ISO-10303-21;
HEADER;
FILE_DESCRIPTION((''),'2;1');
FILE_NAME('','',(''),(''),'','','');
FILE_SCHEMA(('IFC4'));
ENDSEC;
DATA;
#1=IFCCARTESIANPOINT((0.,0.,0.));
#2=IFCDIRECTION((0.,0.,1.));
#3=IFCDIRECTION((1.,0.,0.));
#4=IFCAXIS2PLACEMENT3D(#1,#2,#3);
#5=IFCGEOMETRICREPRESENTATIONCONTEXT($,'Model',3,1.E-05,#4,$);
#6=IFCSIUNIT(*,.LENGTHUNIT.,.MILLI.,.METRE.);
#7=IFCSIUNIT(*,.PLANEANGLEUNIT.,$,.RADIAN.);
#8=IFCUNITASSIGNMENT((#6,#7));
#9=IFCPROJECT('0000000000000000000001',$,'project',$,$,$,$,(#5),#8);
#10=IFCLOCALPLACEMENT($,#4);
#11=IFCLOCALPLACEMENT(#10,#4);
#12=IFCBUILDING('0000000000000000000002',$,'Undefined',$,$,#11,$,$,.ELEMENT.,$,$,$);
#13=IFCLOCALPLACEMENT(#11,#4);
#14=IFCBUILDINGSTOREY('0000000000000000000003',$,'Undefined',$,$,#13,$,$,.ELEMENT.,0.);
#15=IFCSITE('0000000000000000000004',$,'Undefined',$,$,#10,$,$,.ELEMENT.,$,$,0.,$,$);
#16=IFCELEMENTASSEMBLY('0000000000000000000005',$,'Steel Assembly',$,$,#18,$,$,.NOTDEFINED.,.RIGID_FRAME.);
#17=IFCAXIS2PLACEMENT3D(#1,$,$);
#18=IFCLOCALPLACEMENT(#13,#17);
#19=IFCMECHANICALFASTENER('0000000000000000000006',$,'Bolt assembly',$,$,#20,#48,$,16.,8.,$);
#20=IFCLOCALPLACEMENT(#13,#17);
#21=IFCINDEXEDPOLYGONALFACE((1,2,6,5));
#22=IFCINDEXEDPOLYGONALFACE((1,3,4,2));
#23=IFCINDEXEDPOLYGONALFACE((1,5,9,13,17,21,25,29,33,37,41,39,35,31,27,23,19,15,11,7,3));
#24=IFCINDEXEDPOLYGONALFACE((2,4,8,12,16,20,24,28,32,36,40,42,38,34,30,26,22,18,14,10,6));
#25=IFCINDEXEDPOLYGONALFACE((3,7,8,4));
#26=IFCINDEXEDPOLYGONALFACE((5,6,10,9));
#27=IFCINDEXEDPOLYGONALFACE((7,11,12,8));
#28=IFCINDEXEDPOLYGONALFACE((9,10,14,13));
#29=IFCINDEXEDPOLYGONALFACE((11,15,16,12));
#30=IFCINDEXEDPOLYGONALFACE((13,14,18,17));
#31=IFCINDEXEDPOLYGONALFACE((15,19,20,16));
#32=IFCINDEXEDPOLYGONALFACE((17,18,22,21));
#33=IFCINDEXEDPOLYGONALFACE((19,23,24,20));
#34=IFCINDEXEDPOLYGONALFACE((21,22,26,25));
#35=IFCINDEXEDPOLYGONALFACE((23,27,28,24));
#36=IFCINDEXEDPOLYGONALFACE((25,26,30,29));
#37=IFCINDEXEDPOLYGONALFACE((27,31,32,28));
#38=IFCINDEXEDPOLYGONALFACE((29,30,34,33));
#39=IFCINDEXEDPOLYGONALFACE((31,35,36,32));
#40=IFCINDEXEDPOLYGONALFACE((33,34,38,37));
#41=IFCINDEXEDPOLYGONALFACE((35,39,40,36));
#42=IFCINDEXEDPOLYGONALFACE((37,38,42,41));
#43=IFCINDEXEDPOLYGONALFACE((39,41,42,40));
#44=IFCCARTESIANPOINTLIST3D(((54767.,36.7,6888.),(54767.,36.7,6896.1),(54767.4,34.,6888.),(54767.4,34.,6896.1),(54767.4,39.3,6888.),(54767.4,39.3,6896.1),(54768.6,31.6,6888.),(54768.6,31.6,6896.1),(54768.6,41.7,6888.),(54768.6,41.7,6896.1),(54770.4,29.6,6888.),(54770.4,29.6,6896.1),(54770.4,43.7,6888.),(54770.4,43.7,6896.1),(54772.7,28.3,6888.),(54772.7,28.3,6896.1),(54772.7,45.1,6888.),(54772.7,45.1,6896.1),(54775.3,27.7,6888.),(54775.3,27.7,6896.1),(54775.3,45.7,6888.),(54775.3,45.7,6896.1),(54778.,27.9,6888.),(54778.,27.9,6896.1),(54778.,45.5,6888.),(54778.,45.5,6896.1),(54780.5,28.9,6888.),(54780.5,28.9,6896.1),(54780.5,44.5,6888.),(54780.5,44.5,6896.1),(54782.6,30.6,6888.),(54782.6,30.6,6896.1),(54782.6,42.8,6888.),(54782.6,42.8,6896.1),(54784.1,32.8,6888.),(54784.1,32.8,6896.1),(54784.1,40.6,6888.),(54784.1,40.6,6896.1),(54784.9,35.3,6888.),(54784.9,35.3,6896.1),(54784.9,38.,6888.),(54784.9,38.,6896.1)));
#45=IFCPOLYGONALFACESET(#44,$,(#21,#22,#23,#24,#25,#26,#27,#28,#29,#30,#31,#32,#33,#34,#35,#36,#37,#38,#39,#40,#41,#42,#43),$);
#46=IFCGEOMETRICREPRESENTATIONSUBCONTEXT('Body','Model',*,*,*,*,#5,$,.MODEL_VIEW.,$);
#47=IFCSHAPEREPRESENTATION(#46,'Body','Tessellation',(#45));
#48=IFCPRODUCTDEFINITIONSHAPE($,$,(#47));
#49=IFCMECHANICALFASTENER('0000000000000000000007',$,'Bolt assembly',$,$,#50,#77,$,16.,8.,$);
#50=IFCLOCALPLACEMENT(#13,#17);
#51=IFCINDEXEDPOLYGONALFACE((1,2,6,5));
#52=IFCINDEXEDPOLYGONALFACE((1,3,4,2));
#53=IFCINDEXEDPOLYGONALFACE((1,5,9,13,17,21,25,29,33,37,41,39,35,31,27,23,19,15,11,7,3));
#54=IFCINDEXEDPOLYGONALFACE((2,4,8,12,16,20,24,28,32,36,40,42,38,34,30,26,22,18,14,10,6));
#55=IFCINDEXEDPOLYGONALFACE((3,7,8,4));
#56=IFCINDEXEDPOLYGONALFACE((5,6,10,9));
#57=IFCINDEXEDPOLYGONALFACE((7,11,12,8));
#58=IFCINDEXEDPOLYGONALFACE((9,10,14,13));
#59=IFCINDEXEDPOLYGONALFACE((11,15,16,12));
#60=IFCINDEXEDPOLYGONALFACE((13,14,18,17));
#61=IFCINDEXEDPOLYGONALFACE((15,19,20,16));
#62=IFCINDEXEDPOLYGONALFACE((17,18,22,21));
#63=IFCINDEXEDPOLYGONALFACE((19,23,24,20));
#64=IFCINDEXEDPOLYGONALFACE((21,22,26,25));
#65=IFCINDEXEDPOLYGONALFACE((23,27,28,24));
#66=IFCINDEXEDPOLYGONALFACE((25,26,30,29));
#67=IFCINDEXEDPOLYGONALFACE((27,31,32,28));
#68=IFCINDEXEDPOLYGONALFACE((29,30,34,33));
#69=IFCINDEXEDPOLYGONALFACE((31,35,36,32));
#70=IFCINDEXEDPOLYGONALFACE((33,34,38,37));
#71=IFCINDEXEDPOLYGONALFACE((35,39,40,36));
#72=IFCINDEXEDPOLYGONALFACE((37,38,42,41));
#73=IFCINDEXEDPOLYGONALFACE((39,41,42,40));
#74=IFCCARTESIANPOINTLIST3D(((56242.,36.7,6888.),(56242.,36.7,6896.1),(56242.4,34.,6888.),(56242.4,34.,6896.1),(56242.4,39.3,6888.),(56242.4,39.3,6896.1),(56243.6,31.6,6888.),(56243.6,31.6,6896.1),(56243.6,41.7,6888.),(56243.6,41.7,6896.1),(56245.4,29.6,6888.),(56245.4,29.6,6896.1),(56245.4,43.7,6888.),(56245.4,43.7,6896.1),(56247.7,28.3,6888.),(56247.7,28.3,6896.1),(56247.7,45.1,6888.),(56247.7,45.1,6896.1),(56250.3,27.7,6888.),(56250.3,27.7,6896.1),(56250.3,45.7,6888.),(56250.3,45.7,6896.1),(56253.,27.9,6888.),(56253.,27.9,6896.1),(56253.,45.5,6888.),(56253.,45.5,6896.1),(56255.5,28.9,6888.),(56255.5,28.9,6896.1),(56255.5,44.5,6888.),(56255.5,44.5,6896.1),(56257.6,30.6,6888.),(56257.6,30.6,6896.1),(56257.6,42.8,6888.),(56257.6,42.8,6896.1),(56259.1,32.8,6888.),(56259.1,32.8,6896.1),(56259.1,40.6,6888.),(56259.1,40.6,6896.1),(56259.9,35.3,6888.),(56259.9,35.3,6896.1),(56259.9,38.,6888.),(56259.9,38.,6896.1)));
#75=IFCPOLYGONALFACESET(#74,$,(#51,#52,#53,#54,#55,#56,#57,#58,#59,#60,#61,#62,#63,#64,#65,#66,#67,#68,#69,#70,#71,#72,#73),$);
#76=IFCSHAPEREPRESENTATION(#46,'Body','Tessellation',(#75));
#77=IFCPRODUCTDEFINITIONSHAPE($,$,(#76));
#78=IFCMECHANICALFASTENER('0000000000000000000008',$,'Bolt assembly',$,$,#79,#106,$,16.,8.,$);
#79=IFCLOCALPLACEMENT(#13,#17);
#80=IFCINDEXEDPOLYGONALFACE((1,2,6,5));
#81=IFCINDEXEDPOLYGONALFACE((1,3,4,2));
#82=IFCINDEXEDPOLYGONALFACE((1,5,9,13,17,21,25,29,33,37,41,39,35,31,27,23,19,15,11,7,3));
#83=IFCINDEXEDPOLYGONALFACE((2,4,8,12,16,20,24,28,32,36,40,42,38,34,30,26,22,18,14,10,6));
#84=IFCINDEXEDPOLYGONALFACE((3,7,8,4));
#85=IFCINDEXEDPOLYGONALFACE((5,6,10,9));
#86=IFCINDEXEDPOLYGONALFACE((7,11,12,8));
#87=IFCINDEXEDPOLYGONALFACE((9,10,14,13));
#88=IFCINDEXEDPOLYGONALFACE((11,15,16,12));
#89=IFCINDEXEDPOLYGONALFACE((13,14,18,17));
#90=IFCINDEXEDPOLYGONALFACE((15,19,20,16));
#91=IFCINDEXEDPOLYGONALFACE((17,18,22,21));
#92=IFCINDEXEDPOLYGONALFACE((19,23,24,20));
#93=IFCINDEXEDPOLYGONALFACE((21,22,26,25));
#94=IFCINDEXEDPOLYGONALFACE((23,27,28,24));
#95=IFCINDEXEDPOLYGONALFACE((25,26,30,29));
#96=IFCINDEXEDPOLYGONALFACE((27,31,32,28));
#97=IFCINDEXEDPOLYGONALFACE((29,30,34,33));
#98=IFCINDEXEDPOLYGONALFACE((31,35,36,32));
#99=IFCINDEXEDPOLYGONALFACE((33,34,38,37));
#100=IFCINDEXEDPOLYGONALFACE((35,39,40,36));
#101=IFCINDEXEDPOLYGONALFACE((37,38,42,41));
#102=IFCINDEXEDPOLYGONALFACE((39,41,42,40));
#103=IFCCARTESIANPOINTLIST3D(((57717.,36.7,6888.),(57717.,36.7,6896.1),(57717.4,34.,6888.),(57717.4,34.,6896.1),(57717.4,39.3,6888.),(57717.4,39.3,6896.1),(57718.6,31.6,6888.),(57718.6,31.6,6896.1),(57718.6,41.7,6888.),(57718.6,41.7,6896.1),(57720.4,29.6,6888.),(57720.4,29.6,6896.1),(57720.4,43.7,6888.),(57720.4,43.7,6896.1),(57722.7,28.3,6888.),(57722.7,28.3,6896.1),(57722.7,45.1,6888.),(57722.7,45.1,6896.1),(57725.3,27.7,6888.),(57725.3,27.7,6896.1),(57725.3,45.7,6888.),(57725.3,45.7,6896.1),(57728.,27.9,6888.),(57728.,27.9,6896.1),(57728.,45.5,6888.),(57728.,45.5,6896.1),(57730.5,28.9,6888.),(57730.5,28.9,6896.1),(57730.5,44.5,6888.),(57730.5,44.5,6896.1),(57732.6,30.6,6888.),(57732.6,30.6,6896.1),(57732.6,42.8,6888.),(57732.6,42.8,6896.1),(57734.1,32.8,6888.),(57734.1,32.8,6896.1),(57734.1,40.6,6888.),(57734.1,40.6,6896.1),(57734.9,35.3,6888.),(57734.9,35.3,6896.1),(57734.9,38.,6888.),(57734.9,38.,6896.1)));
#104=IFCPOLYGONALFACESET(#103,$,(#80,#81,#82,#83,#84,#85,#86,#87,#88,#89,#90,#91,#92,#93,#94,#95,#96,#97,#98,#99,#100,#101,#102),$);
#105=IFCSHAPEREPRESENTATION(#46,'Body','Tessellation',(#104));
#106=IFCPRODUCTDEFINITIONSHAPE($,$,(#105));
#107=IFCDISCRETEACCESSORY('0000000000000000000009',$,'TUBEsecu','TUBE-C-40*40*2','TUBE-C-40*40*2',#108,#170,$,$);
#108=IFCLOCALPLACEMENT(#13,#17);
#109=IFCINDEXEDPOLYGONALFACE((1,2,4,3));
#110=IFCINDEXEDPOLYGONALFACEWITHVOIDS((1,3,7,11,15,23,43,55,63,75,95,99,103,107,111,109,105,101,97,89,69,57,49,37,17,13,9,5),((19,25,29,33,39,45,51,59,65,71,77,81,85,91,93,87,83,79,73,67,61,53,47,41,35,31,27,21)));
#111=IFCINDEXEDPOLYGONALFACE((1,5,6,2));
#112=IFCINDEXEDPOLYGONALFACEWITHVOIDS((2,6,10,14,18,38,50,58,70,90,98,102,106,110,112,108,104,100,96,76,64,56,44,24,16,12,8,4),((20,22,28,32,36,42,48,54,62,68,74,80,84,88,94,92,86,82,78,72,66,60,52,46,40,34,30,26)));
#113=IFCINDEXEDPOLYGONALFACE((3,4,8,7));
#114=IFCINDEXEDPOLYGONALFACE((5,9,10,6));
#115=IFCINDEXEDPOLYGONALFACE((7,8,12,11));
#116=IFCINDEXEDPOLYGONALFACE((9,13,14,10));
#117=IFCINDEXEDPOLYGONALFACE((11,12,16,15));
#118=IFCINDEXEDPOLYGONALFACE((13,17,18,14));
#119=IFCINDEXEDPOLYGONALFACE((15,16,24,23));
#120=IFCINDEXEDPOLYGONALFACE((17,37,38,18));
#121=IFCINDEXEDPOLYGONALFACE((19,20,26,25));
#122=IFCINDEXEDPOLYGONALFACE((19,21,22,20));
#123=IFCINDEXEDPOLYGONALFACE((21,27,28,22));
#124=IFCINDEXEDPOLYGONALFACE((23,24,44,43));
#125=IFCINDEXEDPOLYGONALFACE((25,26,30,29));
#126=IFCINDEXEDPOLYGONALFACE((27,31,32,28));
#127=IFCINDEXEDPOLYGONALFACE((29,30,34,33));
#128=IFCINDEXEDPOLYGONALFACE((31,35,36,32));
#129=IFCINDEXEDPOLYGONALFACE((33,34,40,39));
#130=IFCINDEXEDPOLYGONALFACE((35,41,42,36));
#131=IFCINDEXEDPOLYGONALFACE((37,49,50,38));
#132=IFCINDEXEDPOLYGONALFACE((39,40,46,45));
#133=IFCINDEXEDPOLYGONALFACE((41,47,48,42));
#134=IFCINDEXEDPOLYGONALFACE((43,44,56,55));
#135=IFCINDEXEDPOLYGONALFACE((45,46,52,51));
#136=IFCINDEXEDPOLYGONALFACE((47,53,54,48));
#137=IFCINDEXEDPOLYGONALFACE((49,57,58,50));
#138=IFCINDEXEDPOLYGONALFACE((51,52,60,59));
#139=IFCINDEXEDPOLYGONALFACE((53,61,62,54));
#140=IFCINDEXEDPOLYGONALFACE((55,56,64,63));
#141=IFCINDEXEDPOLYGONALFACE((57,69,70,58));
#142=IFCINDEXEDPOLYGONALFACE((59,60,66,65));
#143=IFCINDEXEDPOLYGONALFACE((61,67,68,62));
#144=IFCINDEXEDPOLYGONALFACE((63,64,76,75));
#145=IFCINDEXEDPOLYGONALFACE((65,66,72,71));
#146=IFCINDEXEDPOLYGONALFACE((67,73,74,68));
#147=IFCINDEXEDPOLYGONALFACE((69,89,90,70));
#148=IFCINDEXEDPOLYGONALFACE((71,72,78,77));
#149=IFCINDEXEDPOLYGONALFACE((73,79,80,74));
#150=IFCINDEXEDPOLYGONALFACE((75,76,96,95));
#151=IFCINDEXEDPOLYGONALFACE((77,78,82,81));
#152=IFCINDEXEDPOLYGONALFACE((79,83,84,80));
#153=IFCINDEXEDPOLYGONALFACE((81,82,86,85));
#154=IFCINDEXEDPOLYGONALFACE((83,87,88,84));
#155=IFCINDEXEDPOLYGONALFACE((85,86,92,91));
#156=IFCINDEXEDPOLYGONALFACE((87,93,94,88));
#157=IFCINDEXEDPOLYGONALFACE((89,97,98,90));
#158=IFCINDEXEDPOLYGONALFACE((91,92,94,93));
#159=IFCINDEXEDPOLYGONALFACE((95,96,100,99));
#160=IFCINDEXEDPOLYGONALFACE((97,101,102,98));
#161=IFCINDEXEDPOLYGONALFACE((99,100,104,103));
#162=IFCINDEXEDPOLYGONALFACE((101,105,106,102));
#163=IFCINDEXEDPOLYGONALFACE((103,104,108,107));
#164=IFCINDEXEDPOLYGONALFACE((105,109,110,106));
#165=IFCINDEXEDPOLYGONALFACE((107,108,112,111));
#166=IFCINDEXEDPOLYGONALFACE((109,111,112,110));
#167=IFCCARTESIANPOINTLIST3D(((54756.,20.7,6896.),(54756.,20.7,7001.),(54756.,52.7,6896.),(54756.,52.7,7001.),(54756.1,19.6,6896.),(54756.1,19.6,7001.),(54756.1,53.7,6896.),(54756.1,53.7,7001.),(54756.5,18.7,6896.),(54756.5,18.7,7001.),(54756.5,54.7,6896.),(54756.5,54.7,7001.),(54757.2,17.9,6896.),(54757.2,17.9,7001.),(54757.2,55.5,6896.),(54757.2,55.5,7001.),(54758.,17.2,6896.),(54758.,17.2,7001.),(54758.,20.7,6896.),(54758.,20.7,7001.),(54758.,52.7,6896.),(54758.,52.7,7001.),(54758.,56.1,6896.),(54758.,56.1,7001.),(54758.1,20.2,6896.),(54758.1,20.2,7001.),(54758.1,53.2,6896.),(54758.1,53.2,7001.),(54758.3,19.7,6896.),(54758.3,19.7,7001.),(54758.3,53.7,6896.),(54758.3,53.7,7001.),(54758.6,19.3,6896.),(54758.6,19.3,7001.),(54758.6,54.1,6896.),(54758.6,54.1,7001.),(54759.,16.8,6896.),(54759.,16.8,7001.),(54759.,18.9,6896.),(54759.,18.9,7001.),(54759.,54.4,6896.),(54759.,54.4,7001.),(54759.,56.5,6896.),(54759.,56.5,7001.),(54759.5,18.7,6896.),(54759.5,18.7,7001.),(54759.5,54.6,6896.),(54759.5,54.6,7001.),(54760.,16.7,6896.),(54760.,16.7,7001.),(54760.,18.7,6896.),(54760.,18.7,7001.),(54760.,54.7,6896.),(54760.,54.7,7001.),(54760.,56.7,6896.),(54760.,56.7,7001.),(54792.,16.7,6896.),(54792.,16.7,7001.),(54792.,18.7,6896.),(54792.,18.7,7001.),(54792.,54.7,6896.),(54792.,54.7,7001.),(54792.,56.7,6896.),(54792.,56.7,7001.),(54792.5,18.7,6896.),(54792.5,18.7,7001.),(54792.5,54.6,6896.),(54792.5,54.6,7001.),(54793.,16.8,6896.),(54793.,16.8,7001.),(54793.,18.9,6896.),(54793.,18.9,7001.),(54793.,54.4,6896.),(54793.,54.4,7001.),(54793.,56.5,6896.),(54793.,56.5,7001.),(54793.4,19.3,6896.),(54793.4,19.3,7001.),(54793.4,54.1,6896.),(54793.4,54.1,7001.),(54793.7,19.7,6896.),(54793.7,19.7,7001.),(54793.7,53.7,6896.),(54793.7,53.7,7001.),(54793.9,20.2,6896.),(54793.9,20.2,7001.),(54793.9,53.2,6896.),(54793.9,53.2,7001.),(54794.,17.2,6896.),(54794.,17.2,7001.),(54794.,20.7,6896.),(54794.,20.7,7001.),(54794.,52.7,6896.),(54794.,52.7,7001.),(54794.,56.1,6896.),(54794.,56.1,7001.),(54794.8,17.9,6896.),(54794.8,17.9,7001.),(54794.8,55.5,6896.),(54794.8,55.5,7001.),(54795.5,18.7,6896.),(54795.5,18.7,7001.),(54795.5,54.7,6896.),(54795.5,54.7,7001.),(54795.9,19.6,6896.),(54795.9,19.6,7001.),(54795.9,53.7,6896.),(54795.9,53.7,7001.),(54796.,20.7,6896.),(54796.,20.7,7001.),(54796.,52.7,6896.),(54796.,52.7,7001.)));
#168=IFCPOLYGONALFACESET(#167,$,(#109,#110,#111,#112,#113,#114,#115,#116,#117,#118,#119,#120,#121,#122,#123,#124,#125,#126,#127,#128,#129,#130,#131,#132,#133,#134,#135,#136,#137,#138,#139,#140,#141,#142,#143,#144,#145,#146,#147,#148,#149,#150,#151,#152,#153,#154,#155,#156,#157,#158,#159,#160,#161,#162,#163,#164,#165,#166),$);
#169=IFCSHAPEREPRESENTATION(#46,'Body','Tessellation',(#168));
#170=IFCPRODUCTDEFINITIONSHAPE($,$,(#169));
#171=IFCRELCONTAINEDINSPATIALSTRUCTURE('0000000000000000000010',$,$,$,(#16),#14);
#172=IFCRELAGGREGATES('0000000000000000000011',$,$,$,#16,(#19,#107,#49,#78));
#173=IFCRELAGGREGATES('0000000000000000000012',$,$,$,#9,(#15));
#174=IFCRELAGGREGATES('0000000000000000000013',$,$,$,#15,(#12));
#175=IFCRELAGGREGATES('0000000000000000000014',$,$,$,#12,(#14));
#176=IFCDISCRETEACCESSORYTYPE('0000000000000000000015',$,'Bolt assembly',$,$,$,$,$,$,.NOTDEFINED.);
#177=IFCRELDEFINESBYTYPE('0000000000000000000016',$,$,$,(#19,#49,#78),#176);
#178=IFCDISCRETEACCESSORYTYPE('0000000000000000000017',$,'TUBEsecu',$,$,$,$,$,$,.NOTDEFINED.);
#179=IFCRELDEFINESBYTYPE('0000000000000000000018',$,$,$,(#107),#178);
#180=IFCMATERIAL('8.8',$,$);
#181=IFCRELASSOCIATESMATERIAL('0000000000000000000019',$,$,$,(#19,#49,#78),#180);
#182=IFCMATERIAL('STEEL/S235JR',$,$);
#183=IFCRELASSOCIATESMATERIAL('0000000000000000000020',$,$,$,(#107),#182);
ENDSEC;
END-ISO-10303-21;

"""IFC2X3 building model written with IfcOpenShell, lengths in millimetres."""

from ifc_helpers import new_model, si_unit, frame, origin_with_axes, origin_2d_with_axis, place, context, subcontext, project, spatial, hollow_rectangle, circle, extrude, source, transform, mapped, material, type_object, element, aggregate, save


model = new_model("IFC2X3")

# Units and contexts
model_context = context("Model", 3, precision=1e-05, world=origin_with_axes())
body_context = subcontext(model_context, "Body", "Model", "MODEL_VIEW")
ifc_project = project(units=[si_unit("LENGTHUNIT", "METRE", prefix="MILLI"), si_unit("PLANEANGLEUNIT", "RADIAN")], contexts=[model_context])

# Site, building, storey
site_placement = place(None, origin_with_axes())
site = spatial("IfcSite", under=ifc_project, at=site_placement, Name="Undefined", CompositionType="ELEMENT", RefElevation=0.0)
building_placement = place(site_placement, origin_with_axes())
building = spatial("IfcBuilding", under=site, at=building_placement, Name="Undefined", CompositionType="ELEMENT")
storey_placement = place(building_placement, origin_with_axes())
storey = spatial("IfcBuildingStorey", under=building, at=storey_placement, Name="Undefined", CompositionType="ELEMENT", Elevation=0.0)

# Element assembly
ifc_material_1 = material(Name="STEEL/S235JR")
assembly_1_placement = place(storey_placement, origin_with_axes())
assembly_1 = element("IfcElementAssembly", 1, at=assembly_1_placement, inside=storey, Name="Steel Assembly", AssemblyPlace="NOTDEFINED", PredefinedType="RIGID_FRAME")

# Shared definitions
discrete_accessory_type_1 = type_object("IfcDiscreteAccessoryType", Name="Bolt assembly")

# Shared definitions
ifc_material_2 = material(Name="8.8")

# Mechanical fasteners
shared_shape_1 = source(origin_with_axes(), body_context, "Body", "SweptSolid", [
    extrude(circle(Radius=9.0, at=origin_2d_with_axis()), frame((0.0, 0.0, 0.0), z_axis=(0.0, 1.0, 0.0), x_axis=(1.0, 0.0, 0.0)), (0.0, 0.0, 1.0), 8.1),
])
mechanical_fastener_1_placement = place(assembly_1_placement, frame((54776.0, 36.7, 6888.0), z_axis=(0.0, 1.0, 0.0), x_axis=(-1.0, 0.0, 0.0)))
mechanical_fastener_1 = element("IfcMechanicalFastener", 2, at=mechanical_fastener_1_placement, type_object=discrete_accessory_type_1, material=ifc_material_2, Name="Bolt assembly", NominalDiameter=16.0, NominalLength=8.0, context=body_context, shape_type="MappedRepresentation", body=[
    mapped(shared_shape_1, transform((0.0, 0.0, 0.0))),
])
mechanical_fastener_2_placement = place(assembly_1_placement, frame((56251.0, 36.7, 6888.0), z_axis=(0.0, 1.0, 0.0), x_axis=(-1.0, 0.0, 0.0)))
mechanical_fastener_2 = element("IfcMechanicalFastener", 3, at=mechanical_fastener_2_placement, type_object=discrete_accessory_type_1, material=ifc_material_2, Name="Bolt assembly", NominalDiameter=16.0, NominalLength=8.0, context=body_context, shape_type="MappedRepresentation", body=[
    mapped(shared_shape_1, transform((0.0, 0.0, 0.0))),
])
mechanical_fastener_3_placement = place(assembly_1_placement, frame((57726.0, 36.7, 6888.0), z_axis=(0.0, 1.0, 0.0), x_axis=(-1.0, 0.0, 0.0)))
mechanical_fastener_3 = element("IfcMechanicalFastener", 4, at=mechanical_fastener_3_placement, type_object=discrete_accessory_type_1, material=ifc_material_2, Name="Bolt assembly", NominalDiameter=16.0, NominalLength=8.0, context=body_context, shape_type="MappedRepresentation", body=[
    mapped(shared_shape_1, transform((0.0, 0.0, 0.0))),
])

# Discrete accessory
discrete_accessory_type_2 = type_object("IfcDiscreteAccessoryType", Name="TUBEsecu")
discrete_accessory_1_placement = place(assembly_1_placement, frame((54776.0, 36.7, 6896.0), z_axis=(0.0, 0.0, 1.0), x_axis=(1.0, 0.0, 0.0)))
discrete_accessory_1 = element("IfcDiscreteAccessory", 5, at=discrete_accessory_1_placement, type_object=discrete_accessory_type_2, material=ifc_material_1, Name="TUBEsecu", Description="TUBE-C-40*40*2", ObjectType="TUBE-C-40*40*2", context=body_context, shape_type="SweptSolid", body=[
    extrude(hollow_rectangle(XDim=40.0, YDim=40.0, WallThickness=2.0, InnerFilletRadius=2.0, OuterFilletRadius=4.0, at=origin_2d_with_axis()), frame((0.0, 0.0, 105.0), z_axis=(0.0, 0.0, -1.0), x_axis=(0.0, -1.0, 0.0)), (0.0, 0.0, 1.0), 105.0),
])
aggregate(assembly_1, [mechanical_fastener_1, discrete_accessory_1, mechanical_fastener_2, mechanical_fastener_3])

save(model, "model.ifc")
